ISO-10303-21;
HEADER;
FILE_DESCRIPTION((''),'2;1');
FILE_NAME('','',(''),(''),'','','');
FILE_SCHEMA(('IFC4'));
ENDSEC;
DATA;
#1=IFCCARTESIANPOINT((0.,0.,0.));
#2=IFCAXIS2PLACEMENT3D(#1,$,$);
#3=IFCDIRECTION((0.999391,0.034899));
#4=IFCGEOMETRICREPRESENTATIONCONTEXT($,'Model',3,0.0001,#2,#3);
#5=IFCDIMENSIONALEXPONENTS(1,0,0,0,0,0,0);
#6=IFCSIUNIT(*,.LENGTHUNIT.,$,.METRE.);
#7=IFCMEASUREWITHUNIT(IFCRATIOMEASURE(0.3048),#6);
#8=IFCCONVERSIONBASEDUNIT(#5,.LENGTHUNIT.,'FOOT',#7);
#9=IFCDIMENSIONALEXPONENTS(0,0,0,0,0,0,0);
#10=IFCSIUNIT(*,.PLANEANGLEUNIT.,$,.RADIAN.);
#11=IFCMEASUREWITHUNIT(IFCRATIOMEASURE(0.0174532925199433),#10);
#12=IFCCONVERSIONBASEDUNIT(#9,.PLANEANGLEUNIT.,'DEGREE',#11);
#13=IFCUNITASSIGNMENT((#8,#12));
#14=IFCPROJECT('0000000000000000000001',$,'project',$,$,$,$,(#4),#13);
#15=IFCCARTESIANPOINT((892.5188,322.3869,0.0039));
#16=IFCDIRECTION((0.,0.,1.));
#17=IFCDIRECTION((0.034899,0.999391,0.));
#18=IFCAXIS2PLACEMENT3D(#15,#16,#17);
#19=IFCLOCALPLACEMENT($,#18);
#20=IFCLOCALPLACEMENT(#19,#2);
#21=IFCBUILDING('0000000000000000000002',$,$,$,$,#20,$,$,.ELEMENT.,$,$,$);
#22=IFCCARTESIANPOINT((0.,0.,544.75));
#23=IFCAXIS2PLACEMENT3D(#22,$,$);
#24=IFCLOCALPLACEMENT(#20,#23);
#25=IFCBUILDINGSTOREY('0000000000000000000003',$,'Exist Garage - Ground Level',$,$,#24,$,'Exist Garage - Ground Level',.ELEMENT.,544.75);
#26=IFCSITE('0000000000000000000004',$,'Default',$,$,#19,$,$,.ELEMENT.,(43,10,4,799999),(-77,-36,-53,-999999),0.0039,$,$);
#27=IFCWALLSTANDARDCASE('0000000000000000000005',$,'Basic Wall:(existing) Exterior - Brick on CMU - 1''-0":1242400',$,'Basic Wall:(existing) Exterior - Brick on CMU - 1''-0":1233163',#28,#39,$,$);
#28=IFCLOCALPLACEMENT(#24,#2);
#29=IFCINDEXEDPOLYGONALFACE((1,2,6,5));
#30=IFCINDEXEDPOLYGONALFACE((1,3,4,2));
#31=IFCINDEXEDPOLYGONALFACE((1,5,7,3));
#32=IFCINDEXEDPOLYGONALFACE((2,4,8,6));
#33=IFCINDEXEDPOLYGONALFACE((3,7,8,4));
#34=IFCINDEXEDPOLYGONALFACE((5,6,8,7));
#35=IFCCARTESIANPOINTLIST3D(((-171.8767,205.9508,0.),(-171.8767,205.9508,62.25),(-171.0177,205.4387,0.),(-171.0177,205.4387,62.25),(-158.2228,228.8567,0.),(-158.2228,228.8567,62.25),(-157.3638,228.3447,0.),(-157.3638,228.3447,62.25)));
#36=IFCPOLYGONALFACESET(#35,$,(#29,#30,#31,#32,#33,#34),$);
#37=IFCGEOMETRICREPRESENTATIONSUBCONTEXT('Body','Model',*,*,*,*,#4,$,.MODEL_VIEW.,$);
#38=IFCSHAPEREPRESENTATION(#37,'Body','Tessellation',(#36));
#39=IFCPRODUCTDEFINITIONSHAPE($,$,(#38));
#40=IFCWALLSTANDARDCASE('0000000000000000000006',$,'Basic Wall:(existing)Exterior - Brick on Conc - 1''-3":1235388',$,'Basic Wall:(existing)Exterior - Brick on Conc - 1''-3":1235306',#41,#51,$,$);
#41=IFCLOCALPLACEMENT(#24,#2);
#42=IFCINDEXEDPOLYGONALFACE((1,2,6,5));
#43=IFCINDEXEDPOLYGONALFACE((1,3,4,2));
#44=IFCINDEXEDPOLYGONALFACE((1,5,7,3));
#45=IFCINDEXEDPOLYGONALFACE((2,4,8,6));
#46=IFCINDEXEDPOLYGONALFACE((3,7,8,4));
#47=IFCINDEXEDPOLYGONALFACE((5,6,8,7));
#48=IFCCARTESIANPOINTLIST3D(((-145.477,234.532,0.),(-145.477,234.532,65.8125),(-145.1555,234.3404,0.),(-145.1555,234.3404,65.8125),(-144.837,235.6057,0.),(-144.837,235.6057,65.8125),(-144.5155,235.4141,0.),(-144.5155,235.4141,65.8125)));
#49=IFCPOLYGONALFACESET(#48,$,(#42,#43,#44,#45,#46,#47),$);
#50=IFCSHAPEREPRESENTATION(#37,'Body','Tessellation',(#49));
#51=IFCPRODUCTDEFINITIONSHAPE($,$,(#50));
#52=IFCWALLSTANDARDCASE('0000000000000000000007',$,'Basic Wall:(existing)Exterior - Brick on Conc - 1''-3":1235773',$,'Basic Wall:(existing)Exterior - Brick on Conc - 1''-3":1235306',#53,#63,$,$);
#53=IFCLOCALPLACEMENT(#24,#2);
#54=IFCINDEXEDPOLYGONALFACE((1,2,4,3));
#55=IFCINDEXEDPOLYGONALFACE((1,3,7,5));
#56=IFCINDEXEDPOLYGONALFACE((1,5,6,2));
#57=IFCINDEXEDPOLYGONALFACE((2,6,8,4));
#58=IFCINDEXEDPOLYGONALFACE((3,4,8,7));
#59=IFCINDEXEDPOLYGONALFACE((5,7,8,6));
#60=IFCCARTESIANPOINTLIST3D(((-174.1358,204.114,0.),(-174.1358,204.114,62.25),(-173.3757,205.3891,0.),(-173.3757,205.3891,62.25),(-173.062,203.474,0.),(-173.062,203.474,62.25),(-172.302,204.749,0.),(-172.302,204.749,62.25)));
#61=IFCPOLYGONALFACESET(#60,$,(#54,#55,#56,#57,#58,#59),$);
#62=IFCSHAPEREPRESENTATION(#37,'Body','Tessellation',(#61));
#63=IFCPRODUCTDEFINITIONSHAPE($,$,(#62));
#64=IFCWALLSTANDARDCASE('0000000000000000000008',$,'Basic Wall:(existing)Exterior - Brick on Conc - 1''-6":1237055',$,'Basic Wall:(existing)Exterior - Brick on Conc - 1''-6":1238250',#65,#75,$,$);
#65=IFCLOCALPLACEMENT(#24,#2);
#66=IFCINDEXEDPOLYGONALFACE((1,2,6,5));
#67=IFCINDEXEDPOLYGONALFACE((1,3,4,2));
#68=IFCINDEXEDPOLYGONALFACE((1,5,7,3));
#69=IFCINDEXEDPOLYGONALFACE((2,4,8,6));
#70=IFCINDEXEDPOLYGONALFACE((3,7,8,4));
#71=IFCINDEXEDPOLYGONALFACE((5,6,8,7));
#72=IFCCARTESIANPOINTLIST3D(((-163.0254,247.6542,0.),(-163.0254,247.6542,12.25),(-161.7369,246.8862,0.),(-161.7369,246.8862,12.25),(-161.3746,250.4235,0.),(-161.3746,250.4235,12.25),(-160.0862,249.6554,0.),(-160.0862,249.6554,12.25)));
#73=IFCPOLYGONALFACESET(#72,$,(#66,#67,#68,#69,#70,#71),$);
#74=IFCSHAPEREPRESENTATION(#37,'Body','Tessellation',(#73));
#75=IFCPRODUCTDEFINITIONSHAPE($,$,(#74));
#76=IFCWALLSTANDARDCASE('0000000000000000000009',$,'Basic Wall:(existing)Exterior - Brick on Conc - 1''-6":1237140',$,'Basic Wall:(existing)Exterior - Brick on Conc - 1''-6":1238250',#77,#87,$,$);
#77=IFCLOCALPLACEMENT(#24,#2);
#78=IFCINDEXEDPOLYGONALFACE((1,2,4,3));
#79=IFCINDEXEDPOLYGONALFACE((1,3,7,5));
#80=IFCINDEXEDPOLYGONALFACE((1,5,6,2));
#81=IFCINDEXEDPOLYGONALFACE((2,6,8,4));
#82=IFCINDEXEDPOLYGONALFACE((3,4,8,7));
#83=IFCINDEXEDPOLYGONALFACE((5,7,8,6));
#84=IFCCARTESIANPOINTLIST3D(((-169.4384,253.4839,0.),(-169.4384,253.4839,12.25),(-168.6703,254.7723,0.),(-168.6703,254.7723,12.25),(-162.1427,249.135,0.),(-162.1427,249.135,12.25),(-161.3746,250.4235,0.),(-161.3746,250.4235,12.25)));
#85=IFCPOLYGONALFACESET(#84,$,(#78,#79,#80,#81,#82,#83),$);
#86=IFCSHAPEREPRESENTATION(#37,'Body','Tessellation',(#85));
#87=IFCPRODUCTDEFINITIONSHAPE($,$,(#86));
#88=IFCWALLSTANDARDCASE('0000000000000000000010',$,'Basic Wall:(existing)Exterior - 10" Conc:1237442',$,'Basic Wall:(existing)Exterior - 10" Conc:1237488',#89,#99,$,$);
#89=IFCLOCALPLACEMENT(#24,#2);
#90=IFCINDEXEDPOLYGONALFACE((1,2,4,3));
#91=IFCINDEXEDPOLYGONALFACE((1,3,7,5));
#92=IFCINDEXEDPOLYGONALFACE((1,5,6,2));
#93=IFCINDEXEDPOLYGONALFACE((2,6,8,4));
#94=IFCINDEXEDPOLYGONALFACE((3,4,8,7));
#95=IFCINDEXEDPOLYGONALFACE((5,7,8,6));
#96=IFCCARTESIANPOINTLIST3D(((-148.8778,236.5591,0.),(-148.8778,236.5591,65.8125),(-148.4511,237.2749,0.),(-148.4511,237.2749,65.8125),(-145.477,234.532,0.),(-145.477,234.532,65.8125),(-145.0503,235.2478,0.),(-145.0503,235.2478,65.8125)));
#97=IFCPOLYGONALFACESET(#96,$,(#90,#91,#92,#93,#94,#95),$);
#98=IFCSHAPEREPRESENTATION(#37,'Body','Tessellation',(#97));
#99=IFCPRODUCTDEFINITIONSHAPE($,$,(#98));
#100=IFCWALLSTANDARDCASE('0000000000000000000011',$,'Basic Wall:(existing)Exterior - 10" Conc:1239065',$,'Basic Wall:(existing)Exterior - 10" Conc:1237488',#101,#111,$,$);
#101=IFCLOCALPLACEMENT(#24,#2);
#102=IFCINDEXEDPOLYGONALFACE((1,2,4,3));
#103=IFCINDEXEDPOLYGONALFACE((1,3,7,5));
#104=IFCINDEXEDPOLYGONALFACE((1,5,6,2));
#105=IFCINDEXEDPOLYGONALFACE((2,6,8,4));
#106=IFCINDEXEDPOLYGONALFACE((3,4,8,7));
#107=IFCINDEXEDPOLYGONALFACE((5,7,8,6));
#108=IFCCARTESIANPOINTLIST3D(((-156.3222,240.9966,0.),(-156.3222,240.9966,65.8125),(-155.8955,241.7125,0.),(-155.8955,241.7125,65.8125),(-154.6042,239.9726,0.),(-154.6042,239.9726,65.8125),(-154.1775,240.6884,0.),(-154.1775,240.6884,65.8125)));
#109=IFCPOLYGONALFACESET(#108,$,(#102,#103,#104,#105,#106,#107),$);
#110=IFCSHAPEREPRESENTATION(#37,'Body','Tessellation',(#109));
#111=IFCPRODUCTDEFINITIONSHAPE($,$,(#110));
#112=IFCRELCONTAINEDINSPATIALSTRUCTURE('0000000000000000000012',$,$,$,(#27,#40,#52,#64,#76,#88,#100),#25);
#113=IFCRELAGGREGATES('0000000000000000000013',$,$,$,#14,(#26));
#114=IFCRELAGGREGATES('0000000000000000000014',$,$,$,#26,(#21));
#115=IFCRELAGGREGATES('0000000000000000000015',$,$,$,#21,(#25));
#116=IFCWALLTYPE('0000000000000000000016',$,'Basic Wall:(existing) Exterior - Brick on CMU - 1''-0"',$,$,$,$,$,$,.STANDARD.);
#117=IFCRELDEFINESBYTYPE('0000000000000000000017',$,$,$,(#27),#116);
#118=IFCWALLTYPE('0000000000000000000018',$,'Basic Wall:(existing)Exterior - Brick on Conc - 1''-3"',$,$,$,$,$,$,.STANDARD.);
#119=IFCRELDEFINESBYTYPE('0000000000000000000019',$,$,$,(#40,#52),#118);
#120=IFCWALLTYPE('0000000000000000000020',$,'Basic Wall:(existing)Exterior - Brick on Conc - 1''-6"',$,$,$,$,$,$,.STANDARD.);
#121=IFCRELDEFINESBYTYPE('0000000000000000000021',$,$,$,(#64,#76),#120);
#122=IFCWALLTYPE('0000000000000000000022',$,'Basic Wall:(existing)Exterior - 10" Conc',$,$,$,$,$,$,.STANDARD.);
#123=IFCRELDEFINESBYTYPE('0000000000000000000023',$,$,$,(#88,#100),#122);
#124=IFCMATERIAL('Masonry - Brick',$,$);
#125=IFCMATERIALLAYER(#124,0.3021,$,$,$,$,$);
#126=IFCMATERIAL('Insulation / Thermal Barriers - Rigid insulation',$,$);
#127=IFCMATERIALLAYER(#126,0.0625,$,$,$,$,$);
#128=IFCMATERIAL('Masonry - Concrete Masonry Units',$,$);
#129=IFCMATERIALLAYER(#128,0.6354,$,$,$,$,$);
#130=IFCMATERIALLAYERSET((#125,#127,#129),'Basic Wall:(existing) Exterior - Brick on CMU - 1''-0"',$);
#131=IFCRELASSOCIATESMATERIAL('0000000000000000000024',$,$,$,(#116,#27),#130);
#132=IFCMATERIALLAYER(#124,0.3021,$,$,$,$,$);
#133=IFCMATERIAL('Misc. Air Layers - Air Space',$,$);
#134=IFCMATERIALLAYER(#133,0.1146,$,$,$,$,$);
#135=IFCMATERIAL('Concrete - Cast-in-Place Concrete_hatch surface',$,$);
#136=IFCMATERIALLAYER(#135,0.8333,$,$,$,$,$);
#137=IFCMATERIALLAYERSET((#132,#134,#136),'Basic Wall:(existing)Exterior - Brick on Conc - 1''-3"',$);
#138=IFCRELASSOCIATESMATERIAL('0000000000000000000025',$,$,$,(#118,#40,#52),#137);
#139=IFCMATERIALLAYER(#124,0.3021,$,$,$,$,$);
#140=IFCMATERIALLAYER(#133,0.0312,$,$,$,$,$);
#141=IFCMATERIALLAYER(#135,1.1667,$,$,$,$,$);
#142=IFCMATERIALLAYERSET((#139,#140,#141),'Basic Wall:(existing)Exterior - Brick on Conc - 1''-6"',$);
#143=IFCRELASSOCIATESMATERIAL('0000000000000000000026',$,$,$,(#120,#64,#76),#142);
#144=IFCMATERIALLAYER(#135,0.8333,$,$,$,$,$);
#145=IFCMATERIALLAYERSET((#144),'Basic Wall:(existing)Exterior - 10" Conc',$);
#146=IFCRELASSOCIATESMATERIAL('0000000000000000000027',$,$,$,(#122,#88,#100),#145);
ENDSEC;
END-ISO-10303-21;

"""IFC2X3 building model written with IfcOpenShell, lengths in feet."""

from ifc_helpers import new_model, entity, si_unit, converted_unit, direction, frame, frame_2d, origin, place, context, subcontext, project, spatial, rectangle, extrude, material, layer, layer_set, layer_usage, type_object, element, save


model = new_model("IFC2X3")

# Units and contexts
model_context = context("Model", 3, precision=0.0001, world=origin(), true_north=direction((0.999391, 0.034899)))
body_context = subcontext(model_context, "Body", "Model", "MODEL_VIEW")
ifc_project = project(units=[converted_unit("LENGTHUNIT", "FOOT", entity("IfcRatioMeasure", 0.3048), si_unit("LENGTHUNIT", "METRE"), dimensions=[1, 0, 0, 0, 0, 0, 0]), converted_unit("PLANEANGLEUNIT", "DEGREE", entity("IfcRatioMeasure", 0.0174532925199433), si_unit("PLANEANGLEUNIT", "RADIAN"), dimensions=[0, 0, 0, 0, 0, 0, 0])], contexts=[model_context])

# Site, building, storey
site_placement = place(None, frame((892.5188, 322.3869, 0.0039), z_axis=(0.0, 0.0, 1.0), x_axis=(0.034899, 0.999391, 0.0)))
site = spatial("IfcSite", under=ifc_project, at=site_placement, Name="Default", CompositionType="ELEMENT", RefLatitude=(43, 10, 4, 799999), RefLongitude=(-77, -36, -53, -999999), RefElevation=0.0039)
building_placement = place(site_placement, origin())
building = spatial("IfcBuilding", under=site, at=building_placement, CompositionType="ELEMENT")
storey_placement = place(building_placement, frame((0.0, 0.0, 544.75)))
storey = spatial("IfcBuildingStorey", under=building, at=storey_placement, Name="Exist Garage - Ground Level", LongName="Exist Garage - Ground Level", CompositionType="ELEMENT", Elevation=544.75)

# Walls
ifc_material_1 = material(Name="Masonry - Brick")
ifc_layer_1 = layer(ifc_material_1, 0.3021)
ifc_material_2 = material(Name="Insulation / Thermal Barriers - Rigid insulation")
ifc_layer_2 = layer(ifc_material_2, 0.0625)
ifc_material_3 = material(Name="Masonry - Concrete Masonry Units")
ifc_layer_3 = layer(ifc_material_3, 0.6354)
ifc_layer_set_1 = layer_set([ifc_layer_1, ifc_layer_2, ifc_layer_3], Name="Basic Wall:(existing) Exterior - Brick on CMU - 1'-0\"")
wall_type_1 = type_object("IfcWallType", Name="Basic Wall:(existing) Exterior - Brick on CMU - 1'-0\"", PredefinedType="STANDARD", material=ifc_layer_set_1)
ifc_layer_usage_1 = layer_usage(ifc_layer_set_1, "AXIS2", "NEGATIVE", 0.5)
wall_1_placement = place(storey_placement, frame((-171.4472, 205.6948, 0.0), z_axis=(0.0, 0.0, 1.0), x_axis=(0.512022, 0.858972, 0.0)))
element("IfcWallStandardCase", 1, at=wall_1_placement, inside=storey, type_object=wall_type_1, material=ifc_layer_usage_1, Name="Basic Wall:(existing) Exterior - Brick on CMU - 1'-0\":1242400", ObjectType="Basic Wall:(existing) Exterior - Brick on CMU - 1'-0\":1233163", context=body_context, shape_type="SweptSolid", body=[
    extrude(rectangle(XDim=26.6667, YDim=1.0, at=frame_2d((13.3333, 0.0), x_axis=(-1.0, 0.0))), origin(), (0.0, 0.0, 1.0), 62.25),
])
ifc_layer_4 = layer(ifc_material_1, 0.3021)
ifc_material_4 = material(Name="Misc. Air Layers - Air Space")
ifc_layer_5 = layer(ifc_material_4, 0.1146)
ifc_material_5 = material(Name="Concrete - Cast-in-Place Concrete_hatch surface")
ifc_layer_6 = layer(ifc_material_5, 0.8333)
ifc_layer_set_2 = layer_set([ifc_layer_4, ifc_layer_5, ifc_layer_6], Name="Basic Wall:(existing)Exterior - Brick on Conc - 1'-3\"")
ifc_layer_usage_2 = layer_usage(ifc_layer_set_2, "AXIS2", "POSITIVE", -0.625)
wall_type_2 = type_object("IfcWallType", Name="Basic Wall:(existing)Exterior - Brick on Conc - 1'-3\"", PredefinedType="STANDARD", material=ifc_layer_set_2)
wall_2_placement = place(storey_placement, frame((-144.8355, 234.8772, 0.0), z_axis=(0.0, 0.0, 1.0), x_axis=(-0.858972, 0.512022, 0.0)))
element("IfcWallStandardCase", 2, at=wall_2_placement, inside=storey, type_object=wall_type_2, material=ifc_layer_usage_2, Name="Basic Wall:(existing)Exterior - Brick on Conc - 1'-3\":1235388", ObjectType="Basic Wall:(existing)Exterior - Brick on Conc - 1'-3\":1235306", context=body_context, shape_type="SweptSolid", body=[
    extrude(rectangle(XDim=0.3743, YDim=1.25, at=frame_2d((0.1871, 0.0), x_axis=(-1.0, 0.0))), origin(), (0.0, 0.0, 1.0), 65.8125),
])
ifc_layer_usage_3 = layer_usage(ifc_layer_set_2, "AXIS2", "NEGATIVE", 0.625)
wall_3_placement = place(storey_placement, frame((-173.5989, 203.794, 0.0), z_axis=(0.0, 0.0, 1.0), x_axis=(0.512022, 0.858972, 0.0)))
element("IfcWallStandardCase", 3, at=wall_3_placement, inside=storey, type_object=wall_type_2, material=ifc_layer_usage_3, Name="Basic Wall:(existing)Exterior - Brick on Conc - 1'-3\":1235773", ObjectType="Basic Wall:(existing)Exterior - Brick on Conc - 1'-3\":1235306", context=body_context, shape_type="SweptSolid", body=[
    extrude(rectangle(XDim=1.4844, YDim=1.25, at=frame_2d((0.7422, 0.0), x_axis=(-1.0, 0.0))), origin(), (0.0, 0.0, 1.0), 62.25),
])
ifc_layer_7 = layer(ifc_material_1, 0.3021)
ifc_layer_8 = layer(ifc_material_4, 0.0312)
ifc_layer_9 = layer(ifc_material_5, 1.1667)
ifc_layer_set_3 = layer_set([ifc_layer_7, ifc_layer_8, ifc_layer_9], Name="Basic Wall:(existing)Exterior - Brick on Conc - 1'-6\"")
ifc_layer_usage_4 = layer_usage(ifc_layer_set_3, "AXIS2", "POSITIVE", -0.75)
wall_type_3 = type_object("IfcWallType", Name="Basic Wall:(existing)Exterior - Brick on Conc - 1'-6\"", PredefinedType="STANDARD", material=ifc_layer_set_3)
wall_4_placement = place(storey_placement, frame((-162.3811, 247.2702, 0.0), z_axis=(0.0, 0.0, 1.0), x_axis=(0.512022, 0.858972, 0.0)))
element("IfcWallStandardCase", 4, at=wall_4_placement, inside=storey, type_object=wall_type_3, material=ifc_layer_usage_4, Name="Basic Wall:(existing)Exterior - Brick on Conc - 1'-6\":1237055", ObjectType="Basic Wall:(existing)Exterior - Brick on Conc - 1'-6\":1238250", context=body_context, shape_type="SweptSolid", body=[
    extrude(rectangle(XDim=3.224, YDim=1.5, at=frame_2d((1.612, 0.0), x_axis=(-1.0, 0.0))), origin(), (0.0, 0.0, 1.0), 12.25),
])
ifc_layer_usage_5 = layer_usage(ifc_layer_set_3, "AXIS2", "NEGATIVE", 0.75)
wall_5_placement = place(storey_placement, frame((-169.0543, 254.1281, 0.0), z_axis=(0.0, 0.0, 1.0), x_axis=(0.858972, -0.512022, 0.0)))
element("IfcWallStandardCase", 5, at=wall_5_placement, inside=storey, type_object=wall_type_3, material=ifc_layer_usage_5, Name="Basic Wall:(existing)Exterior - Brick on Conc - 1'-6\":1237140", ObjectType="Basic Wall:(existing)Exterior - Brick on Conc - 1'-6\":1238250", context=body_context, shape_type="SweptSolid", body=[
    extrude(rectangle(XDim=8.4935, YDim=1.5, at=frame_2d((4.2467, 0.0), x_axis=(-1.0, 0.0))), origin(), (0.0, 0.0, 1.0), 12.25),
])
ifc_layer_10 = layer(ifc_material_5, 0.8333)
ifc_layer_set_4 = layer_set([ifc_layer_10], Name="Basic Wall:(existing)Exterior - 10\" Conc")
ifc_layer_usage_6 = layer_usage(ifc_layer_set_4, "AXIS2", "POSITIVE", -0.4167)
wall_type_4 = type_object("IfcWallType", Name="Basic Wall:(existing)Exterior - 10\" Conc", PredefinedType="STANDARD", material=ifc_layer_set_4)
wall_6_placement = place(storey_placement, frame((-145.2637, 234.8899, 0.0), z_axis=(0.0, 0.0, 1.0), x_axis=(-0.858972, 0.512022, 0.0)))
element("IfcWallStandardCase", 6, at=wall_6_placement, inside=storey, type_object=wall_type_4, material=ifc_layer_usage_6, Name="Basic Wall:(existing)Exterior - 10\" Conc:1237442", ObjectType="Basic Wall:(existing)Exterior - 10\" Conc:1237488", context=body_context, shape_type="SweptSolid", body=[
    extrude(rectangle(XDim=3.9591, YDim=0.8333, at=frame_2d((1.9795, 0.0), x_axis=(-1.0, 0.0))), origin(), (0.0, 0.0, 1.0), 65.8125),
])
ifc_layer_usage_7 = layer_usage(ifc_layer_set_4, "AXIS2", "POSITIVE", -0.4167)
wall_7_placement = place(storey_placement, frame((-154.3909, 240.3305, 0.0), z_axis=(0.0, 0.0, 1.0), x_axis=(-0.858972, 0.512022, 0.0)))
element("IfcWallStandardCase", 7, at=wall_7_placement, inside=storey, type_object=wall_type_4, material=ifc_layer_usage_7, Name="Basic Wall:(existing)Exterior - 10\" Conc:1239065", ObjectType="Basic Wall:(existing)Exterior - 10\" Conc:1237488", context=body_context, shape_type="SweptSolid", body=[
    extrude(rectangle(XDim=2.0, YDim=0.8333, at=frame_2d((1.0, 0.0), x_axis=(-1.0, 0.0))), origin(), (0.0, 0.0, 1.0), 65.8125),
])

save(model, "model.ifc")
